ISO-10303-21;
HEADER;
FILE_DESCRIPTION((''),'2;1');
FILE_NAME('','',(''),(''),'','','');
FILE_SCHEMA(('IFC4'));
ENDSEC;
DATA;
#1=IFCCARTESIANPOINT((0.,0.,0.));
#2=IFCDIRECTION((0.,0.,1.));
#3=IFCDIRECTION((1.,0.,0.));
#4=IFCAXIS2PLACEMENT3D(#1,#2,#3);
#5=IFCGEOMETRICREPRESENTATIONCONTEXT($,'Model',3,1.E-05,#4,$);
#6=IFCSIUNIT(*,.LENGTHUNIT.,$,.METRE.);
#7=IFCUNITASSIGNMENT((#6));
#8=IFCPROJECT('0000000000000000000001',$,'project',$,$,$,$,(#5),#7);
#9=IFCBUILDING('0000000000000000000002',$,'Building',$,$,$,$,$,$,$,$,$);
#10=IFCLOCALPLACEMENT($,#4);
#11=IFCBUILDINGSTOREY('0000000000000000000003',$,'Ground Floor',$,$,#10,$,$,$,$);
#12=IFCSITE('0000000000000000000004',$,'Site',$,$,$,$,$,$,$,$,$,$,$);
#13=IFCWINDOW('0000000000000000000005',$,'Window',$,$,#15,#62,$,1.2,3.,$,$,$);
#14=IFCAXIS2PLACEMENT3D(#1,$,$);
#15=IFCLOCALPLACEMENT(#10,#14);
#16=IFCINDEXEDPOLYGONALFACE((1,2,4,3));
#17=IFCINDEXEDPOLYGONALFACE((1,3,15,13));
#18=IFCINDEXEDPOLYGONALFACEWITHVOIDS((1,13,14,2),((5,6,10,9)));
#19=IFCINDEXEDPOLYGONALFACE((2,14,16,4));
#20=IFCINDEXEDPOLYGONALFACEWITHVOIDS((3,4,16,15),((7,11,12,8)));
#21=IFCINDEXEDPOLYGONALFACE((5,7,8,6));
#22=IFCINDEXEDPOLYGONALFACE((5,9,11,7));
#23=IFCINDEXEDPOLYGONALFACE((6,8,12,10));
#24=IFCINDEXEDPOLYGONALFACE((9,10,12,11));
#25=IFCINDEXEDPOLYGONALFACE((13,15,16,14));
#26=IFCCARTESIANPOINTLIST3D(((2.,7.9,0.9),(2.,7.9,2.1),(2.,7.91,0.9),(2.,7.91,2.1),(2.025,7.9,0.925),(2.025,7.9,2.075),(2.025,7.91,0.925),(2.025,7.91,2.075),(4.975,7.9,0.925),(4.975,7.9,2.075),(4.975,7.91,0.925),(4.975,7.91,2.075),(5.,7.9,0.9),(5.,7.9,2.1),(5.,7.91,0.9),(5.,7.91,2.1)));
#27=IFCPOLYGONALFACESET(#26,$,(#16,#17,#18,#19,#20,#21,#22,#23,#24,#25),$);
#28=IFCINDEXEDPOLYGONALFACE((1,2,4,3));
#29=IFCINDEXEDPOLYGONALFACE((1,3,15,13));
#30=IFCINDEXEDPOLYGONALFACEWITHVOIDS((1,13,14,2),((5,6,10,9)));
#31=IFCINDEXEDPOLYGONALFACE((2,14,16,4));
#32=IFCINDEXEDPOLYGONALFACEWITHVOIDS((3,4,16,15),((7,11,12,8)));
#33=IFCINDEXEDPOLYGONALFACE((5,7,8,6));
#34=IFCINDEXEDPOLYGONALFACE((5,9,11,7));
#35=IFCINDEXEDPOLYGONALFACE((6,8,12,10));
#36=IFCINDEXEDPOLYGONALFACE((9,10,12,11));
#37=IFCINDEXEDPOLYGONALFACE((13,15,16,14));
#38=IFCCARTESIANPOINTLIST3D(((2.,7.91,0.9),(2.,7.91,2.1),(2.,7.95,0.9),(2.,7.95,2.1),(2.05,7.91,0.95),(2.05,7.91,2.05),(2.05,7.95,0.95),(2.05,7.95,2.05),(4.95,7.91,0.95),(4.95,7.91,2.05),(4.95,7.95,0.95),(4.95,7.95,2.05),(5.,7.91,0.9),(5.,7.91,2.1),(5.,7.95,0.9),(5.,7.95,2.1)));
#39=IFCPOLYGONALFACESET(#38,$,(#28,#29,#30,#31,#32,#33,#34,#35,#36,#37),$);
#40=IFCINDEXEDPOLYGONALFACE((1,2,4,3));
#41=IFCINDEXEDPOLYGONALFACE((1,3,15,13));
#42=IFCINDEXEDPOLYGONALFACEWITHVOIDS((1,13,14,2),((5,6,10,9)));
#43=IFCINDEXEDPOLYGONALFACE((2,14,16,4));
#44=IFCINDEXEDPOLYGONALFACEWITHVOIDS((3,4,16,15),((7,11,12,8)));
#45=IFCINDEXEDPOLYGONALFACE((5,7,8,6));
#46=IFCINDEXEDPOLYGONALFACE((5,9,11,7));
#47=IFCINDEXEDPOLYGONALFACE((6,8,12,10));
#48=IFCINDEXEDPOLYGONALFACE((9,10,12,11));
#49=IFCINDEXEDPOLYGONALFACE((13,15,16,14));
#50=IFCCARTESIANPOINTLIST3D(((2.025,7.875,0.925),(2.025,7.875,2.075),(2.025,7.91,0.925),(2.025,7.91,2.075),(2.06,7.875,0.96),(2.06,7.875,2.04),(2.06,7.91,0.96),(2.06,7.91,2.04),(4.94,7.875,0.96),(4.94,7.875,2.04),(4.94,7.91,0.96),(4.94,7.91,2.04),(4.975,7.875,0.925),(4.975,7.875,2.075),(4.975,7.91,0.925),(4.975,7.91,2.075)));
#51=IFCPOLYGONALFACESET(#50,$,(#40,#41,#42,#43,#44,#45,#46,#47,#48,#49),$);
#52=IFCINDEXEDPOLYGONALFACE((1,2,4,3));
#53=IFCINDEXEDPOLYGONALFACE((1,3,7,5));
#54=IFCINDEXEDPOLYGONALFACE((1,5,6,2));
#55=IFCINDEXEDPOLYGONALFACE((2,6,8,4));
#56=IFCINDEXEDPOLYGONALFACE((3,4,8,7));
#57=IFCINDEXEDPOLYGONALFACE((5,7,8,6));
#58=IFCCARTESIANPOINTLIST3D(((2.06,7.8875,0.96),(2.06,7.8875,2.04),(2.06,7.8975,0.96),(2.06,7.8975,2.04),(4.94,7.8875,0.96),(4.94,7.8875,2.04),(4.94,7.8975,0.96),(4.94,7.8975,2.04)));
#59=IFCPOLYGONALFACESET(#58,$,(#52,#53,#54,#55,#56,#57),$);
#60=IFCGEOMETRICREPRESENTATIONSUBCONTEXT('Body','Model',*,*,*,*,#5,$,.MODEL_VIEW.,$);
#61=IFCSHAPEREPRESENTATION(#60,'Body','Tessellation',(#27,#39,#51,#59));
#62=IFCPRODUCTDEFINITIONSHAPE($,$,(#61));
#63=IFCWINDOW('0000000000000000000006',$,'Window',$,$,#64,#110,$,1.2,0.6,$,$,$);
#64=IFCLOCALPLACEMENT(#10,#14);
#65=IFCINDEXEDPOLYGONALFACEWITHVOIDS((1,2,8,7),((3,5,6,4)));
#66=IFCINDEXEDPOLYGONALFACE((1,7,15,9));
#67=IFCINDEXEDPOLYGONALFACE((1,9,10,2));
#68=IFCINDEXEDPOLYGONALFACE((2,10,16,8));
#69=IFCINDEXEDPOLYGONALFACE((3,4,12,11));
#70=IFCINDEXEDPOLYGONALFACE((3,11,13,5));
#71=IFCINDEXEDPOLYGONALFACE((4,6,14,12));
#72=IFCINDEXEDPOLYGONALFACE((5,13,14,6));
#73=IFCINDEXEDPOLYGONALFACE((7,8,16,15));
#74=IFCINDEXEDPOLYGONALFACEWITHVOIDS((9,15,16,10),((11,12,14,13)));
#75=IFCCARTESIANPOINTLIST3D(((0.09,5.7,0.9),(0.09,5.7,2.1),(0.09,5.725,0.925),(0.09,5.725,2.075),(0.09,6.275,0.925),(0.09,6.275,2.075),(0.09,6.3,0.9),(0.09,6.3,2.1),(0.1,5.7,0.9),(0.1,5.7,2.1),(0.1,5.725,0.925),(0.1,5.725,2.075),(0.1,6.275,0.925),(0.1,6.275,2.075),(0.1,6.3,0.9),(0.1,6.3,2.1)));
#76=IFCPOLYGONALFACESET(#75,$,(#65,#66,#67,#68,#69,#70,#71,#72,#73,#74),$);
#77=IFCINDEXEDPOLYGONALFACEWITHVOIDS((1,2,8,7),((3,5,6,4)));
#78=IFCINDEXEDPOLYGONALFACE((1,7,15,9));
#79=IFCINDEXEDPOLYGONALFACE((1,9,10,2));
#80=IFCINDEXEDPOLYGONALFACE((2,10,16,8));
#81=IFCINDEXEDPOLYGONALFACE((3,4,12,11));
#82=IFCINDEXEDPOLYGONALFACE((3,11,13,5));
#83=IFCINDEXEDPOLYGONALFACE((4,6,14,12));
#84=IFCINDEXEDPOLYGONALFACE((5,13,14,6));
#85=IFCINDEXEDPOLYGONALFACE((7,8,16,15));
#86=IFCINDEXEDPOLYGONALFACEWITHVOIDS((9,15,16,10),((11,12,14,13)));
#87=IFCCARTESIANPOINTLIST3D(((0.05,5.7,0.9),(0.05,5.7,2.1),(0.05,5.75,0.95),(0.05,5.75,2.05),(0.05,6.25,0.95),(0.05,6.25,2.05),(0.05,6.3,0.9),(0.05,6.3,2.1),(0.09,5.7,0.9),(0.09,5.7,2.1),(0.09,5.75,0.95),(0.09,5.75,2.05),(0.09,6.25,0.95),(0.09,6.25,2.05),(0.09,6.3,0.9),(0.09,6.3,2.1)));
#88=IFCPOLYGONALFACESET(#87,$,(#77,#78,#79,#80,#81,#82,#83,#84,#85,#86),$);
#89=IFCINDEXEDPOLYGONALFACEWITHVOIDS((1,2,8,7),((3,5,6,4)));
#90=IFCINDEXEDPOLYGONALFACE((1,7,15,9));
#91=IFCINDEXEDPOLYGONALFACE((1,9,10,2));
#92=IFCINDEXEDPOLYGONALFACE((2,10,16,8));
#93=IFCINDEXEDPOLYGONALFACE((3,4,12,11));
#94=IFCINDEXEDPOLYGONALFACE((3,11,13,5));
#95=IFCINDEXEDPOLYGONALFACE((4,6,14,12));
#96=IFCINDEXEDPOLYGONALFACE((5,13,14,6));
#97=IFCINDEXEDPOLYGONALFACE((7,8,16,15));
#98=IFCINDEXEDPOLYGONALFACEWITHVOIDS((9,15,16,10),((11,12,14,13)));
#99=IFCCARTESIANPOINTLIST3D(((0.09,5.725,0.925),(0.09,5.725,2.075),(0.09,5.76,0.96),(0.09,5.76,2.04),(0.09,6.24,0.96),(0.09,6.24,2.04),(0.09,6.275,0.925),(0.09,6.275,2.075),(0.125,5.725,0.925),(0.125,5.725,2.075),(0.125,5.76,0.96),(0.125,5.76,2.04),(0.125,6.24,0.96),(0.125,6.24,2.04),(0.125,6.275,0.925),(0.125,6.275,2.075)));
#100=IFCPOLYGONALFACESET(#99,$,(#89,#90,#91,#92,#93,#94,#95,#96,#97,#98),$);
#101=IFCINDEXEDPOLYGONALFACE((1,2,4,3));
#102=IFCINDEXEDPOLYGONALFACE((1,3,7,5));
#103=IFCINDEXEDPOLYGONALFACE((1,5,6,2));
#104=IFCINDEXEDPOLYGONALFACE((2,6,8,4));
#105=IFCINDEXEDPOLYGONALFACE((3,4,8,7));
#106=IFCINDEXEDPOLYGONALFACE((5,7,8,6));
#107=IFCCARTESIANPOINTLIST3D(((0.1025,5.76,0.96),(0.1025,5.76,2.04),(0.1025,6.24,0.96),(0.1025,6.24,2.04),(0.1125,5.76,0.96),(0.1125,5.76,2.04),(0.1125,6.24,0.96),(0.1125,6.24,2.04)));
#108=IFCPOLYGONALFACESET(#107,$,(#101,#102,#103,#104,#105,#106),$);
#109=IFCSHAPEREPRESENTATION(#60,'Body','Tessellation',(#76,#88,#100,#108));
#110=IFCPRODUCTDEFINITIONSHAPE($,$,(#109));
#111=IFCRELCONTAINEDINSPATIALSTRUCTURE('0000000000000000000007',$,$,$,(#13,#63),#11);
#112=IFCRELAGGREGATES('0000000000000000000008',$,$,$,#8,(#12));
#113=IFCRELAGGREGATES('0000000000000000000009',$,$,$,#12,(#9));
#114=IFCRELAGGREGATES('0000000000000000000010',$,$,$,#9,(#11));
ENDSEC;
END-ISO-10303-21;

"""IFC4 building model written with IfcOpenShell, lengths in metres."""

from ifc_helpers import new_model, si_unit, frame, origin_with_axes, place, context, subcontext, project, spatial, line, indexed_curve, outline, extrude, element, save


model = new_model("IFC4")

# Units and contexts
model_context = context("Model", 3, precision=1e-05, world=origin_with_axes())
body_context = subcontext(model_context, "Body", "Model", "MODEL_VIEW")
ifc_project = project(units=[si_unit("LENGTHUNIT", "METRE")], contexts=[model_context])

# Site, building, storey
site = spatial("IfcSite", under=ifc_project, Name="Site")
building = spatial("IfcBuilding", under=site, Name="Building")
storey_placement = place(None, origin_with_axes())
storey = spatial("IfcBuildingStorey", under=building, at=storey_placement, Name="Ground Floor")

# Windows
window_1_placement = place(storey_placement, frame((5.0, 8.0, 0.9), z_axis=(0.0, 0.0, 1.0), x_axis=(-1.0, 0.0, 0.0)))
element("IfcWindow", 1, at=window_1_placement, inside=storey, Name="Window", OverallHeight=1.2, OverallWidth=3.0, context=body_context, shape_type="SweptSolid", body=[
    extrude(outline(indexed_curve([(0.0, 0.0), (3.0, 0.0), (3.0, 1.2), (0.0, 1.2)], segments=[line(1, 2, 3, 4, 1)]), holes=[indexed_curve([(0.025, 0.025), (2.975, 0.025), (2.975, 1.175), (0.025, 1.175)], segments=[line(1, 2, 3, 4, 1)])]), frame((0.0, 0.09, 0.0), z_axis=(0.0, -1.0, 0.0), x_axis=(1.0, 0.0, 0.0)), (0.0, 0.0, -1.0), 0.01),
    extrude(outline(indexed_curve([(0.0, 0.0), (3.0, 0.0), (3.0, 1.2), (0.0, 1.2)], segments=[line(1, 2, 3, 4, 1)]), holes=[indexed_curve([(0.05, 0.05), (2.95, 0.05), (2.95, 1.15), (0.05, 1.15)], segments=[line(1, 2, 3, 4, 1)])]), frame((0.0, 0.05, 0.0), z_axis=(0.0, -1.0, 0.0), x_axis=(1.0, 0.0, 0.0)), (0.0, 0.0, -1.0), 0.04),
    extrude(outline(indexed_curve([(0.0, 0.0), (2.95, 0.0), (2.95, 1.15), (0.0, 1.15)], segments=[line(1, 2, 3, 4, 1)]), holes=[indexed_curve([(0.035, 0.035), (2.915, 0.035), (2.915, 1.115), (0.035, 1.115)], segments=[line(1, 2, 3, 4, 1)])]), frame((0.025, 0.09, 0.025), z_axis=(0.0, -1.0, 0.0), x_axis=(1.0, 0.0, 0.0)), (0.0, 0.0, -1.0), 0.035),
    extrude(outline(indexed_curve([(0.035, 0.035), (2.915, 0.035), (2.915, 1.115), (0.035, 1.115)], segments=[line(1, 2, 3, 4, 1)])), frame((0.025, 0.1025, 0.025), z_axis=(0.0, -1.0, 0.0), x_axis=(1.0, 0.0, 0.0)), (0.0, 0.0, -1.0), 0.01),
])
window_2_placement = place(storey_placement, frame((0.0, 6.3, 0.9), z_axis=(0.0, 0.0, 1.0), x_axis=(0.0, -1.0, 0.0)))
element("IfcWindow", 2, at=window_2_placement, inside=storey, Name="Window", OverallHeight=1.2, OverallWidth=0.6, context=body_context, shape_type="SweptSolid", body=[
    extrude(outline(indexed_curve([(0.0, 0.0), (0.6, 0.0), (0.6, 1.2), (0.0, 1.2)], segments=[line(1, 2, 3, 4, 1)]), holes=[indexed_curve([(0.025, 0.025), (0.575, 0.025), (0.575, 1.175), (0.025, 1.175)], segments=[line(1, 2, 3, 4, 1)])]), frame((0.0, 0.09, 0.0), z_axis=(0.0, -1.0, 0.0), x_axis=(1.0, 0.0, 0.0)), (0.0, 0.0, -1.0), 0.01),
    extrude(outline(indexed_curve([(0.0, 0.0), (0.6, 0.0), (0.6, 1.2), (0.0, 1.2)], segments=[line(1, 2, 3, 4, 1)]), holes=[indexed_curve([(0.05, 0.05), (0.55, 0.05), (0.55, 1.15), (0.05, 1.15)], segments=[line(1, 2, 3, 4, 1)])]), frame((0.0, 0.05, 0.0), z_axis=(0.0, -1.0, 0.0), x_axis=(1.0, 0.0, 0.0)), (0.0, 0.0, -1.0), 0.04),
    extrude(outline(indexed_curve([(0.0, 0.0), (0.55, 0.0), (0.55, 1.15), (0.0, 1.15)], segments=[line(1, 2, 3, 4, 1)]), holes=[indexed_curve([(0.035, 0.035), (0.515, 0.035), (0.515, 1.115), (0.035, 1.115)], segments=[line(1, 2, 3, 4, 1)])]), frame((0.025, 0.09, 0.025), z_axis=(0.0, -1.0, 0.0), x_axis=(1.0, 0.0, 0.0)), (0.0, 0.0, -1.0), 0.035),
    extrude(outline(indexed_curve([(0.035, 0.035), (0.515, 0.035), (0.515, 1.115), (0.035, 1.115)], segments=[line(1, 2, 3, 4, 1)])), frame((0.025, 0.1025, 0.025), z_axis=(0.0, -1.0, 0.0), x_axis=(1.0, 0.0, 0.0)), (0.0, 0.0, -1.0), 0.01),
])

save(model, "model.ifc")
